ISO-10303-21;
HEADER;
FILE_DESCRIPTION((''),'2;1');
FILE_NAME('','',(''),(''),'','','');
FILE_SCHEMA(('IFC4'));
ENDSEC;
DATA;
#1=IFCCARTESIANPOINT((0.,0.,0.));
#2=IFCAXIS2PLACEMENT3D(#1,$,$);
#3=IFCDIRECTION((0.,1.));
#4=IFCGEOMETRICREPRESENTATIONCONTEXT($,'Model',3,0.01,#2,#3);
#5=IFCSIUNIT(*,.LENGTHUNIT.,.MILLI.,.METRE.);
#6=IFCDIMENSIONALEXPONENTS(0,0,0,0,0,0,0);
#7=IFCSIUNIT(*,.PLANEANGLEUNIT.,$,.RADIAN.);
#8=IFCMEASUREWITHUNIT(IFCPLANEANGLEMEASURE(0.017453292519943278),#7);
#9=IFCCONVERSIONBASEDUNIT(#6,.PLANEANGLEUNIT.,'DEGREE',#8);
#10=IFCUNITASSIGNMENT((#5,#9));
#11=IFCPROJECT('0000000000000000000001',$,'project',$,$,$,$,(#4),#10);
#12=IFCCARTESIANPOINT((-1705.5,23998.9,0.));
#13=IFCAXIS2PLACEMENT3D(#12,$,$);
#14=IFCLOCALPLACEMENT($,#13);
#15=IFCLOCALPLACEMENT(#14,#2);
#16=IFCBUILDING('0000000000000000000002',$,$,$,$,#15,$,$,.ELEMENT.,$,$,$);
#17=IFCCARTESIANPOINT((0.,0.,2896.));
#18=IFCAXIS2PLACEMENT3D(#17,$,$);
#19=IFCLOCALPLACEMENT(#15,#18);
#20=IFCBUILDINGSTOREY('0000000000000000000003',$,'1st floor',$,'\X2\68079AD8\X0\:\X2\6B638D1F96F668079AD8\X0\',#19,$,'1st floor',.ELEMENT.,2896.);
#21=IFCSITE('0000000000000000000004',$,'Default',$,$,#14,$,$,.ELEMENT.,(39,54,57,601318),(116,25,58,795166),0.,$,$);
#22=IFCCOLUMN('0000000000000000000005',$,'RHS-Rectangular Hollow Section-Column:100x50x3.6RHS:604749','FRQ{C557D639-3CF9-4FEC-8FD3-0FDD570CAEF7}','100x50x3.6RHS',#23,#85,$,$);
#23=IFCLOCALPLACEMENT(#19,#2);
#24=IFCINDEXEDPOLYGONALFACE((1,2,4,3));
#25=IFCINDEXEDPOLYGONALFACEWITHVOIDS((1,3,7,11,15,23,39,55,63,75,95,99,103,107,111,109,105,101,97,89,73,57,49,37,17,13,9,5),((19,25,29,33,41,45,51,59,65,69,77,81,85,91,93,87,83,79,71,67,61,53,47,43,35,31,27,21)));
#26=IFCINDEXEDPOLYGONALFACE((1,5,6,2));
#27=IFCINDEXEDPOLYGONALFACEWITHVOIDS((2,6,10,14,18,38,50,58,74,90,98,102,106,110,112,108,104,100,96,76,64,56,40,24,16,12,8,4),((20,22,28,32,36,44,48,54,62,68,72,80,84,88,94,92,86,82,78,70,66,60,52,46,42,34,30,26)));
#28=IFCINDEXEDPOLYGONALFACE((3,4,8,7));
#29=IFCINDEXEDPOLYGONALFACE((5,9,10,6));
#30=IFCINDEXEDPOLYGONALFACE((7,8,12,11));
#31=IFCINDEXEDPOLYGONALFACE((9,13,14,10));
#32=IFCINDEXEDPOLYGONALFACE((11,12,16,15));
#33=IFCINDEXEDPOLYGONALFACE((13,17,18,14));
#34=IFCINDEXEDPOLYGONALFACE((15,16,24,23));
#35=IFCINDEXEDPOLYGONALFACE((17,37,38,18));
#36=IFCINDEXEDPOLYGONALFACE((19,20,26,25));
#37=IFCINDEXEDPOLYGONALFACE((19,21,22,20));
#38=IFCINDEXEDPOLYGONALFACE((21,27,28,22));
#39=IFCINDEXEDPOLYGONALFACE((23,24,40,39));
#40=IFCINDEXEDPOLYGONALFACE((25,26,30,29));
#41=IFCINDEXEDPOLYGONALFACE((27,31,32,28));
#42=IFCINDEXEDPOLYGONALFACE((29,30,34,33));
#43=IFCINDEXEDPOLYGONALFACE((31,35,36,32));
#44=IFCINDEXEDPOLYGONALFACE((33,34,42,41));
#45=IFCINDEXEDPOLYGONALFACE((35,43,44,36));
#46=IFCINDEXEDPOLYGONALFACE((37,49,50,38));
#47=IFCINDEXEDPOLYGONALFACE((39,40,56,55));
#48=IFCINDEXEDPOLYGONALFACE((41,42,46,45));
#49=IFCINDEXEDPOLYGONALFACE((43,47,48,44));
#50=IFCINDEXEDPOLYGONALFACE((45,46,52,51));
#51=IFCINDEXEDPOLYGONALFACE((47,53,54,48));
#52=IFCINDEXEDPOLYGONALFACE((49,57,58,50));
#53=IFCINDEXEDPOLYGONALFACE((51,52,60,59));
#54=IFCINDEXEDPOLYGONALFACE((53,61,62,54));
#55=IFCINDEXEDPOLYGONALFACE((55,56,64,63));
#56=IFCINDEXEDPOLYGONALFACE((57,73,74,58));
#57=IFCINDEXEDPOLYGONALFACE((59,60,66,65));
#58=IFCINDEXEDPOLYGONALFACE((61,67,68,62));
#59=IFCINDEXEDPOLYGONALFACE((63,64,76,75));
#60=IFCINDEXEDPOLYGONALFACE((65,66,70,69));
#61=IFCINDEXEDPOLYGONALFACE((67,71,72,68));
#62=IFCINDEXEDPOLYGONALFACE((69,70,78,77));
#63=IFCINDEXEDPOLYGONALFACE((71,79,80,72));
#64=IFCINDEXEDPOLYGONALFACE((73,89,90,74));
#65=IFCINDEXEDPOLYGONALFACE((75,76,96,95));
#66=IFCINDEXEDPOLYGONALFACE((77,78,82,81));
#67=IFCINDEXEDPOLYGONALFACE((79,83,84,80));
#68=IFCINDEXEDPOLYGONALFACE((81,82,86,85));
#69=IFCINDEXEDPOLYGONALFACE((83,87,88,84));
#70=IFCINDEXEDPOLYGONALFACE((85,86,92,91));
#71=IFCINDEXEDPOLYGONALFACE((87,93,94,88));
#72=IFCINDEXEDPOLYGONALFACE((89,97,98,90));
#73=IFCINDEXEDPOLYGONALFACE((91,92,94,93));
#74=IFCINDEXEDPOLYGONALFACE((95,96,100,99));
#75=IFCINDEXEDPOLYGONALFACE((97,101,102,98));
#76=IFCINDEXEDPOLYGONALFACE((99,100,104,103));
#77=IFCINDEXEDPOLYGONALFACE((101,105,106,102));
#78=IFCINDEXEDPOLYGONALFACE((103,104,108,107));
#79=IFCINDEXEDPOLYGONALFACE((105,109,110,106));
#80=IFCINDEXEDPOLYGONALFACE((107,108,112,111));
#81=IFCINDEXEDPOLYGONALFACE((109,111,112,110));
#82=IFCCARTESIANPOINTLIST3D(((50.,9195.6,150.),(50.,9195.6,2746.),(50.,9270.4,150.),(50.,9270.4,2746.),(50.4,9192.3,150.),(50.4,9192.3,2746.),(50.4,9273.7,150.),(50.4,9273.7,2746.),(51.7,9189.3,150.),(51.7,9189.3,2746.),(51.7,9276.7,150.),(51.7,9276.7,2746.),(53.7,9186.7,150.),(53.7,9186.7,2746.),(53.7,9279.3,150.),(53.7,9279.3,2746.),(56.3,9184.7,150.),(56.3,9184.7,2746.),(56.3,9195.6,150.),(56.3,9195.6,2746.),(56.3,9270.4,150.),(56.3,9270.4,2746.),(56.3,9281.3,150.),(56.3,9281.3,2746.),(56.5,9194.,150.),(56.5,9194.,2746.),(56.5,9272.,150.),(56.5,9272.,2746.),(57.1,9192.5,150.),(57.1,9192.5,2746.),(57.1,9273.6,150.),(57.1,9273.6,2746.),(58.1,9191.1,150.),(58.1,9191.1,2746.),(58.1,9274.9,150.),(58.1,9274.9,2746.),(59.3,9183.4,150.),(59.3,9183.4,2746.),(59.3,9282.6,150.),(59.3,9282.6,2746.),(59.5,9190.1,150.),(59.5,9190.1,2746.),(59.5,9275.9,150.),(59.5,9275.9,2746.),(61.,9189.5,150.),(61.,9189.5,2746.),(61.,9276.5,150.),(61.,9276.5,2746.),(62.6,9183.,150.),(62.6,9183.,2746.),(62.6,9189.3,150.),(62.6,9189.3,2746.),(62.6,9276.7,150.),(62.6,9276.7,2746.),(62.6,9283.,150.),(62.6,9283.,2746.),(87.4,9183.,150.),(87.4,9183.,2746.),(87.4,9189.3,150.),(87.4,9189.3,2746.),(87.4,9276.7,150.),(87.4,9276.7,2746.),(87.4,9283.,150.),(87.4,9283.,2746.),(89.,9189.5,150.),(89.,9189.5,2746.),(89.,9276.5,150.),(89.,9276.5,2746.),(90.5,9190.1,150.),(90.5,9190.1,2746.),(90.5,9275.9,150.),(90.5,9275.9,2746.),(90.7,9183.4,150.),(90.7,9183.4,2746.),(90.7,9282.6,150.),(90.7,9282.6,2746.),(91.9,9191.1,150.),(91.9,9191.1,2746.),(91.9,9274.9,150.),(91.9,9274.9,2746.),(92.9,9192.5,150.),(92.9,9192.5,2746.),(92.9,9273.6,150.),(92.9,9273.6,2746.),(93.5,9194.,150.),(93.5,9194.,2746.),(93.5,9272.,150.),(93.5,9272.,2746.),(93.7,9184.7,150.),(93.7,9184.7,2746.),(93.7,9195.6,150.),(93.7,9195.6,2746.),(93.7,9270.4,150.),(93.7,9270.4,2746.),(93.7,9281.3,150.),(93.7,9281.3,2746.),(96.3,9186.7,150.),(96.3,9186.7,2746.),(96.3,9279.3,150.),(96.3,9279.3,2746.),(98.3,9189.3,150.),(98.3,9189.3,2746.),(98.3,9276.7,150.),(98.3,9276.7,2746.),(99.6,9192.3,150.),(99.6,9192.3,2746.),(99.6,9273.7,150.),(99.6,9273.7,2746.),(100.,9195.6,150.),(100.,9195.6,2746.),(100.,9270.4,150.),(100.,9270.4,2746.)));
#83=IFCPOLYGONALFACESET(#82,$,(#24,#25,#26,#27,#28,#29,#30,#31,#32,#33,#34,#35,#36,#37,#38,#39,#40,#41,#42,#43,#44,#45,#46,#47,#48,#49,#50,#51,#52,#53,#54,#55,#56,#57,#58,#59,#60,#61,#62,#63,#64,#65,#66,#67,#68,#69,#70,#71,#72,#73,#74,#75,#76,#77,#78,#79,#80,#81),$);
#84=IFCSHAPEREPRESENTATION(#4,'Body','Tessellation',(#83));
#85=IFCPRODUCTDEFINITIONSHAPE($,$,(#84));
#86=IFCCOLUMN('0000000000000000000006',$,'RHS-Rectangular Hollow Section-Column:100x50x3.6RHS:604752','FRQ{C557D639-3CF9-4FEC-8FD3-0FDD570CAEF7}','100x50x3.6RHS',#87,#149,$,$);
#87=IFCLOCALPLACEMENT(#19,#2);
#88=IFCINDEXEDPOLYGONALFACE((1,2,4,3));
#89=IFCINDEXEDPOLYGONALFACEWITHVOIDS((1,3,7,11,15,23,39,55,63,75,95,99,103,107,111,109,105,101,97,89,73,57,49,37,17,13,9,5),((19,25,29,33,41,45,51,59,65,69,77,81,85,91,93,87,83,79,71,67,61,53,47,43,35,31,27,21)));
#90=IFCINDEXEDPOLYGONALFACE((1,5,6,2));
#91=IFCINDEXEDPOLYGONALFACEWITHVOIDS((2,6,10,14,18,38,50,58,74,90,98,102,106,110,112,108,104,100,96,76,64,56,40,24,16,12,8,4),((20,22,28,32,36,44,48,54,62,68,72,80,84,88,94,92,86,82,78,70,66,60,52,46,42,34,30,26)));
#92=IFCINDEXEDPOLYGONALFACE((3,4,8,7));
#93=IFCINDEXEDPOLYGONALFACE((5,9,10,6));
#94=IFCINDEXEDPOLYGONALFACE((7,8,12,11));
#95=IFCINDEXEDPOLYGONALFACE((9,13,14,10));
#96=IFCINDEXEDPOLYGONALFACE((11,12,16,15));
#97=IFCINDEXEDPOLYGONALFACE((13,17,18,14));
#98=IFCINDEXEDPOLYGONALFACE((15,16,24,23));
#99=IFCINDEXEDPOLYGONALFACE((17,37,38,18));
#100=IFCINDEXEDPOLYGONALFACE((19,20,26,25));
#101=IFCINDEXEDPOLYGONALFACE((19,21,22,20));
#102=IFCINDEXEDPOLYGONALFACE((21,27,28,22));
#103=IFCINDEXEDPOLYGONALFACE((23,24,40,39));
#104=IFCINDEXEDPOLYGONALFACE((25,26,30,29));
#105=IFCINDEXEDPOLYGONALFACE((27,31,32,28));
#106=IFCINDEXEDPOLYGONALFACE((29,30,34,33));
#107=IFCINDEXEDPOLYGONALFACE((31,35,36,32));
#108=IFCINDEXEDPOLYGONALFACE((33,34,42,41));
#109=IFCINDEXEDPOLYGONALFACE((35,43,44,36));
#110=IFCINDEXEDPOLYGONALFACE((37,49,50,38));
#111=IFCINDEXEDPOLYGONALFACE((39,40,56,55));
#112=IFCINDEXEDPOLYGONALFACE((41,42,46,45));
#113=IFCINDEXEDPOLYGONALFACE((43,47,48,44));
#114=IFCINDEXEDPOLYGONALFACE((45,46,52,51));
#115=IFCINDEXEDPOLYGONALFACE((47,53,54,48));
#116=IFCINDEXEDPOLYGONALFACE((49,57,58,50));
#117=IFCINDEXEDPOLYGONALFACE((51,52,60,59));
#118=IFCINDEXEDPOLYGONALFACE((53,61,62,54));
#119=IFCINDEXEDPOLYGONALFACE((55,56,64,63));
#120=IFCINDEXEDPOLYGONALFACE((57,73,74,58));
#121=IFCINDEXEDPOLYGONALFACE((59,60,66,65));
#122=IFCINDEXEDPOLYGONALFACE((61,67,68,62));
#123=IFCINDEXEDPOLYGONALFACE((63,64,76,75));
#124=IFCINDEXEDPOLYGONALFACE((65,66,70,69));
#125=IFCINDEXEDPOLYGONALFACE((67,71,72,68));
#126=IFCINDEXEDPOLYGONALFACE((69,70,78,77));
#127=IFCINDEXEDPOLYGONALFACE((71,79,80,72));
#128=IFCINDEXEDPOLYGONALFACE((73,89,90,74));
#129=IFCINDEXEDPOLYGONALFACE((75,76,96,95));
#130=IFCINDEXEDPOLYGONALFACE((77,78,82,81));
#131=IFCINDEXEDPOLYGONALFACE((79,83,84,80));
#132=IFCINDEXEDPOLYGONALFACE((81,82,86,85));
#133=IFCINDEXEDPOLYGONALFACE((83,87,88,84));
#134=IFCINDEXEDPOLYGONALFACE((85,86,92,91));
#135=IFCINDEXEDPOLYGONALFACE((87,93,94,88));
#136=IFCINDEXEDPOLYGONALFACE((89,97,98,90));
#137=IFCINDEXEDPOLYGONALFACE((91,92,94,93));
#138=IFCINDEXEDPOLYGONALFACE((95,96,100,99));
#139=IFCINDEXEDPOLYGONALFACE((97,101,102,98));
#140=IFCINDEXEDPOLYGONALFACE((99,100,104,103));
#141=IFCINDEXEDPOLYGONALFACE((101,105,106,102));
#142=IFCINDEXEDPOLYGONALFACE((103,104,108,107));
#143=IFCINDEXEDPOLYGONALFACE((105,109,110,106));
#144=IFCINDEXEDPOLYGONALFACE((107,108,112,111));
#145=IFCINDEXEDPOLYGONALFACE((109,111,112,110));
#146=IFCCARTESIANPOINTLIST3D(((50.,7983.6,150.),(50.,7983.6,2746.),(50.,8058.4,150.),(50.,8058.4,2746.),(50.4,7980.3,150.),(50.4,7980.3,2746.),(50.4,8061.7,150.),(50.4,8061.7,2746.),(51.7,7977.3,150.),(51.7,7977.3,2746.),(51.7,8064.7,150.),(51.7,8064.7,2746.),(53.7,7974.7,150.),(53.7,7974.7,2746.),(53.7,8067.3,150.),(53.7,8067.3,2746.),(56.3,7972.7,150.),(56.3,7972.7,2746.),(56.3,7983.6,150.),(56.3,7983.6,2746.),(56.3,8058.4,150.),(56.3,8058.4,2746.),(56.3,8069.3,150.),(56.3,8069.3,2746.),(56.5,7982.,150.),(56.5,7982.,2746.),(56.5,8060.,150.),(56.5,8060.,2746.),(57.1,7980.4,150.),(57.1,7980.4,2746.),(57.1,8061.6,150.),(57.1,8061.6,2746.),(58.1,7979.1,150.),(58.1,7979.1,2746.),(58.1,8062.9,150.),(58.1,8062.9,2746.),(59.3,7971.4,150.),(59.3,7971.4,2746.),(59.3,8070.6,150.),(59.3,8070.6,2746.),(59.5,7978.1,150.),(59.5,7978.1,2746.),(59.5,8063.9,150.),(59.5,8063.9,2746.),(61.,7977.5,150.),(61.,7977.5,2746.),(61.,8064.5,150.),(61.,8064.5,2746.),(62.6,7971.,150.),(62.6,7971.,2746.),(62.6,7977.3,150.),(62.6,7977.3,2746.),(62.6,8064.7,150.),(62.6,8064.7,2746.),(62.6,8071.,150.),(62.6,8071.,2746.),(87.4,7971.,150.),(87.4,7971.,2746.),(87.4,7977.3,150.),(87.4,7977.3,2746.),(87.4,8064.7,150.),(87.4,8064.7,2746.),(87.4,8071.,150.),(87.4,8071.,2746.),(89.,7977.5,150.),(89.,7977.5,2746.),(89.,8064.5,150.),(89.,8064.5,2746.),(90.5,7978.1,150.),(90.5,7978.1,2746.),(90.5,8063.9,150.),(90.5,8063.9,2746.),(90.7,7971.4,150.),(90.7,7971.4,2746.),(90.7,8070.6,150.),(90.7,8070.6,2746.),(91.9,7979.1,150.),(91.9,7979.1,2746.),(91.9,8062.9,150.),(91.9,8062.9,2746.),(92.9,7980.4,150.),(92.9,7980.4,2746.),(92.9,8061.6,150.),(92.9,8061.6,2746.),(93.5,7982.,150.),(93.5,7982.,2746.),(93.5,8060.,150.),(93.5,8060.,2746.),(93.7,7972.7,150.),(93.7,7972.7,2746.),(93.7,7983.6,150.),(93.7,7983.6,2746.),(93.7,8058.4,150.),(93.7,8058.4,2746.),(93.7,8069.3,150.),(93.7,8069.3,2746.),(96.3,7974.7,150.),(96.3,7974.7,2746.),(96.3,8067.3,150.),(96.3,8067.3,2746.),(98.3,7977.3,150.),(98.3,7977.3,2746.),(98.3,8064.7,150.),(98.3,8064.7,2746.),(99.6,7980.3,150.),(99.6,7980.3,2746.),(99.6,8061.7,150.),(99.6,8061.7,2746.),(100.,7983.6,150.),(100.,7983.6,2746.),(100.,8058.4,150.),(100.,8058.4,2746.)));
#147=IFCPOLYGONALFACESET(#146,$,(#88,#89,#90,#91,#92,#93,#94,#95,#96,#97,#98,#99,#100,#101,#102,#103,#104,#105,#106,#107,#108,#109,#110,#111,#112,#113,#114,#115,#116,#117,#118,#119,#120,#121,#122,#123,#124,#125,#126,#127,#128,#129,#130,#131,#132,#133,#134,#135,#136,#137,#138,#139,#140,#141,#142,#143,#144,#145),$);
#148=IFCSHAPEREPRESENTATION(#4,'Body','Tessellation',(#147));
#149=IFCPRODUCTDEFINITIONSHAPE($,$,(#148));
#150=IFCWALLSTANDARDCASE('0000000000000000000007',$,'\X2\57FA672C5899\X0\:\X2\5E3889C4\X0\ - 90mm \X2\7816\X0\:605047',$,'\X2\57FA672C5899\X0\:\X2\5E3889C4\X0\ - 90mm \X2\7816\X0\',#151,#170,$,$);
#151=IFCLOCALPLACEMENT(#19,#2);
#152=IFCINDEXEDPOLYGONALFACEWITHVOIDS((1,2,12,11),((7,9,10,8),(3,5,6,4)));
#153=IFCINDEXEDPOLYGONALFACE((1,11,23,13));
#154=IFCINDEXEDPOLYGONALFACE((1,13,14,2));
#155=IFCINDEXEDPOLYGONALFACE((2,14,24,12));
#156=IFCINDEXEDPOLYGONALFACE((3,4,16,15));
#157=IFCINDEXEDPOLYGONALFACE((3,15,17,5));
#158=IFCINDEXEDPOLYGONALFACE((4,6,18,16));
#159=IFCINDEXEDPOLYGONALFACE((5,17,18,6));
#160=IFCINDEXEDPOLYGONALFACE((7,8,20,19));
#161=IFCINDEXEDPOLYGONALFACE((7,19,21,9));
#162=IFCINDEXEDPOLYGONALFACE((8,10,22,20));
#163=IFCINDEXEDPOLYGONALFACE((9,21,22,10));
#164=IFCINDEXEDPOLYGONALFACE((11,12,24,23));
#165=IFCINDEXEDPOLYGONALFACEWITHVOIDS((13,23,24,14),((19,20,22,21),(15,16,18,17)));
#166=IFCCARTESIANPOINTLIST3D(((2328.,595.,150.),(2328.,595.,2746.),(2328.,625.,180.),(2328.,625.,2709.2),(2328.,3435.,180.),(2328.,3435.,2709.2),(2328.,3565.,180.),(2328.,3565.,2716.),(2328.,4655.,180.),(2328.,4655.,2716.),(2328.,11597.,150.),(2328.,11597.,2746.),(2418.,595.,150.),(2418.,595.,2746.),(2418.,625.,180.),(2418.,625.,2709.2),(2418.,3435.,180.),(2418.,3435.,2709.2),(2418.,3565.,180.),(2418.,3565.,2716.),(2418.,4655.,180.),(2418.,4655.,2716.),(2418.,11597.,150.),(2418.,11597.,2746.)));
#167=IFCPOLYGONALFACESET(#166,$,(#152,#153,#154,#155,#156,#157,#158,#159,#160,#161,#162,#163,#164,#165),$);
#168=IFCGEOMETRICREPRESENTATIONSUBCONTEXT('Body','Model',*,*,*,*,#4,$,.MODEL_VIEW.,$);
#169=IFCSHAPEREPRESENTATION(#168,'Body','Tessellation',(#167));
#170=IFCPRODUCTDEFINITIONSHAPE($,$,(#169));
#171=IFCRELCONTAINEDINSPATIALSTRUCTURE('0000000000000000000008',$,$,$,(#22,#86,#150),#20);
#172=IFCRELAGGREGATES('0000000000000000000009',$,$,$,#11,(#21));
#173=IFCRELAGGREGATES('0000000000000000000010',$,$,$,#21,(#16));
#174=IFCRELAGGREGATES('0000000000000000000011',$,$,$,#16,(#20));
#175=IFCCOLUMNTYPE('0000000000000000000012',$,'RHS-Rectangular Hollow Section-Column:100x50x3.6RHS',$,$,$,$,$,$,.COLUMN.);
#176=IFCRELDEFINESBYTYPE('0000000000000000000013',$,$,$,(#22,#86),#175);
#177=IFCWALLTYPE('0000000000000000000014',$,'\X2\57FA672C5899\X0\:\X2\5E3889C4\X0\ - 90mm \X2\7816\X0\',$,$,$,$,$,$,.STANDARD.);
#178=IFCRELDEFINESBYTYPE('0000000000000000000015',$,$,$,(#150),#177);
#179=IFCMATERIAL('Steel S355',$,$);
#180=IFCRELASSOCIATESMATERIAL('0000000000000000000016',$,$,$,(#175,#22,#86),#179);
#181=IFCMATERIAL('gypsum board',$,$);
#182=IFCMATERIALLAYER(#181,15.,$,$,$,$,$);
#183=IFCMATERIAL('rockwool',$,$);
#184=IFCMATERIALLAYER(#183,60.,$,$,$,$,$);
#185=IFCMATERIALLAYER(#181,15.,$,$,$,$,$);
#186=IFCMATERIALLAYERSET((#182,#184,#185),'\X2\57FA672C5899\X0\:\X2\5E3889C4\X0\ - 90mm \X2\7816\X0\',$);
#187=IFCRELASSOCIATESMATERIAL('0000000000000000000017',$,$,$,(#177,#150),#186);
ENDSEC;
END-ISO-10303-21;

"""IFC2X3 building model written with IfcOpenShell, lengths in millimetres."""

from ifc_helpers import new_model, entity, si_unit, converted_unit, direction, frame, frame_2d, origin, origin_2d, place, context, subcontext, project, spatial, rectangle, hollow_rectangle, extrude, clip, halfspace, material, layer, layer_set, layer_usage, type_object, element, save


model = new_model("IFC2X3")

# Units and contexts
model_context = context("Model", 3, precision=0.01, world=origin(), true_north=direction((0.0, 1.0)))
body_context = subcontext(model_context, "Body", "Model", "MODEL_VIEW")
ifc_project = project(units=[si_unit("LENGTHUNIT", "METRE", prefix="MILLI"), converted_unit("PLANEANGLEUNIT", "DEGREE", entity("IfcPlaneAngleMeasure", 0.017453292519943278), si_unit("PLANEANGLEUNIT", "RADIAN"), dimensions=[0, 0, 0, 0, 0, 0, 0])], contexts=[model_context])

# Site, building, storey
site_placement = place(None, frame((-1705.5, 23998.9, 0.0)))
site = spatial("IfcSite", under=ifc_project, at=site_placement, Name="Default", CompositionType="ELEMENT", RefLatitude=(39, 54, 57, 601318), RefLongitude=(116, 25, 58, 795166), RefElevation=0.0)
building_placement = place(site_placement, origin())
building = spatial("IfcBuilding", under=site, at=building_placement, CompositionType="ELEMENT")
storey_placement = place(building_placement, frame((0.0, 0.0, 2896.0)))
storey = spatial("IfcBuildingStorey", under=building, at=storey_placement, Name="1st floor", ObjectType="标高:正负零标高", LongName="1st floor", CompositionType="ELEMENT", Elevation=2896.0)

# Columns
ifc_material_1 = material(Name="Steel S355")
column_type = type_object("IfcColumnType", Name="RHS-Rectangular Hollow Section-Column:100x50x3.6RHS", PredefinedType="COLUMN", material=ifc_material_1)
column_1_placement = place(storey_placement, frame((75.0, 9233.0, 2746.0), z_axis=(0.0, 0.0, 1.0), x_axis=(-1.0, 0.0, 0.0)))
element("IfcColumn", 1, at=column_1_placement, inside=storey, type_object=column_type, material=ifc_material_1, Name="RHS-Rectangular Hollow Section-Column:100x50x3.6RHS:604749", Description="FRQ{C557D639-3CF9-4FEC-8FD3-0FDD570CAEF7}", ObjectType="100x50x3.6RHS", context=model_context, shape_type="Clipping", body=[
    clip(extrude(hollow_rectangle(XDim=50.0, YDim=100.0, WallThickness=6.3, InnerFilletRadius=6.3, OuterFilletRadius=12.6, at=origin_2d()), origin(), (0.0, 0.0, -1.0), 2651.9), halfspace(frame((75.0, 9233.0, -2596.0), z_axis=(0.0, 0.0, 1.0), x_axis=(-1.0, 0.0, 0.0)), True)),
])
column_2_placement = place(storey_placement, frame((75.0, 8021.0, 2746.0), z_axis=(0.0, 0.0, 1.0), x_axis=(-1.0, 0.0, 0.0)))
element("IfcColumn", 2, at=column_2_placement, inside=storey, type_object=column_type, material=ifc_material_1, Name="RHS-Rectangular Hollow Section-Column:100x50x3.6RHS:604752", Description="FRQ{C557D639-3CF9-4FEC-8FD3-0FDD570CAEF7}", ObjectType="100x50x3.6RHS", context=model_context, shape_type="Clipping", body=[
    clip(extrude(hollow_rectangle(XDim=50.0, YDim=100.0, WallThickness=6.3, InnerFilletRadius=6.3, OuterFilletRadius=12.6, at=origin_2d()), origin(), (0.0, 0.0, -1.0), 2651.9), halfspace(frame((75.0, 8021.0, -2596.0), z_axis=(0.0, 0.0, 1.0), x_axis=(-1.0, 0.0, 0.0)), True)),
])

# Wall, openings
ifc_material_2 = material(Name="gypsum board")
ifc_layer_1 = layer(ifc_material_2, 15.0)
ifc_material_3 = material(Name="rockwool")
ifc_layer_2 = layer(ifc_material_3, 60.0)
ifc_layer_3 = layer(ifc_material_2, 15.0)
ifc_layer_set = layer_set([ifc_layer_1, ifc_layer_2, ifc_layer_3], Name="基本墙:常规 - 90mm 砖")
ifc_layer_usage = layer_usage(ifc_layer_set, "AXIS2", "NEGATIVE", 45.0)
wall_type = type_object("IfcWallType", Name="基本墙:常规 - 90mm 砖", PredefinedType="STANDARD", material=ifc_layer_set)
wall_placement = place(storey_placement, frame((2373.0, 11597.0, 150.0), z_axis=(0.0, 0.0, 1.0), x_axis=(0.0, -1.0, 0.0)))
wall = element("IfcWallStandardCase", 3, at=wall_placement, inside=storey, type_object=wall_type, material=ifc_layer_usage, Name="基本墙:常规 - 90mm 砖:605047", ObjectType="基本墙:常规 - 90mm 砖", context=body_context, shape_type="SweptSolid", body=[
    extrude(rectangle(XDim=11002.0, YDim=90.0, at=frame_2d((5501.0, 0.0), x_axis=(-1.0, 0.0))), origin(), (0.0, 0.0, 1.0), 2596.0),
])
opening_1_placement = place(wall_placement, origin())
element("IfcOpeningElement", 4, at=opening_1_placement, cuts=wall, ObjectType="Opening", context=body_context, shape_type="SweptSolid", body=[
    extrude(rectangle(XDim=2536.0, YDim=1090.0, at=frame_2d((0.0, 0.0), x_axis=(0.0, 1.0))), frame((7487.0, 45.0, 1298.0), z_axis=(0.0, -1.0, 0.0), x_axis=(-1.0, 0.0, 0.0)), (0.0, 0.0, 1.0), 90.0),
])
opening_2_placement = place(wall_placement, origin())
element("IfcOpeningElement", 5, at=opening_2_placement, cuts=wall, ObjectType="Opening", context=body_context, shape_type="SweptSolid", body=[
    extrude(rectangle(XDim=2529.2, YDim=2810.0, at=frame_2d((0.0, 0.0), x_axis=(0.0, 1.0))), frame((9567.0, 45.0, 1294.6), z_axis=(0.0, -1.0, 0.0), x_axis=(-1.0, 0.0, 0.0)), (0.0, 0.0, 1.0), 90.0),
])

save(model, "model.ifc")
